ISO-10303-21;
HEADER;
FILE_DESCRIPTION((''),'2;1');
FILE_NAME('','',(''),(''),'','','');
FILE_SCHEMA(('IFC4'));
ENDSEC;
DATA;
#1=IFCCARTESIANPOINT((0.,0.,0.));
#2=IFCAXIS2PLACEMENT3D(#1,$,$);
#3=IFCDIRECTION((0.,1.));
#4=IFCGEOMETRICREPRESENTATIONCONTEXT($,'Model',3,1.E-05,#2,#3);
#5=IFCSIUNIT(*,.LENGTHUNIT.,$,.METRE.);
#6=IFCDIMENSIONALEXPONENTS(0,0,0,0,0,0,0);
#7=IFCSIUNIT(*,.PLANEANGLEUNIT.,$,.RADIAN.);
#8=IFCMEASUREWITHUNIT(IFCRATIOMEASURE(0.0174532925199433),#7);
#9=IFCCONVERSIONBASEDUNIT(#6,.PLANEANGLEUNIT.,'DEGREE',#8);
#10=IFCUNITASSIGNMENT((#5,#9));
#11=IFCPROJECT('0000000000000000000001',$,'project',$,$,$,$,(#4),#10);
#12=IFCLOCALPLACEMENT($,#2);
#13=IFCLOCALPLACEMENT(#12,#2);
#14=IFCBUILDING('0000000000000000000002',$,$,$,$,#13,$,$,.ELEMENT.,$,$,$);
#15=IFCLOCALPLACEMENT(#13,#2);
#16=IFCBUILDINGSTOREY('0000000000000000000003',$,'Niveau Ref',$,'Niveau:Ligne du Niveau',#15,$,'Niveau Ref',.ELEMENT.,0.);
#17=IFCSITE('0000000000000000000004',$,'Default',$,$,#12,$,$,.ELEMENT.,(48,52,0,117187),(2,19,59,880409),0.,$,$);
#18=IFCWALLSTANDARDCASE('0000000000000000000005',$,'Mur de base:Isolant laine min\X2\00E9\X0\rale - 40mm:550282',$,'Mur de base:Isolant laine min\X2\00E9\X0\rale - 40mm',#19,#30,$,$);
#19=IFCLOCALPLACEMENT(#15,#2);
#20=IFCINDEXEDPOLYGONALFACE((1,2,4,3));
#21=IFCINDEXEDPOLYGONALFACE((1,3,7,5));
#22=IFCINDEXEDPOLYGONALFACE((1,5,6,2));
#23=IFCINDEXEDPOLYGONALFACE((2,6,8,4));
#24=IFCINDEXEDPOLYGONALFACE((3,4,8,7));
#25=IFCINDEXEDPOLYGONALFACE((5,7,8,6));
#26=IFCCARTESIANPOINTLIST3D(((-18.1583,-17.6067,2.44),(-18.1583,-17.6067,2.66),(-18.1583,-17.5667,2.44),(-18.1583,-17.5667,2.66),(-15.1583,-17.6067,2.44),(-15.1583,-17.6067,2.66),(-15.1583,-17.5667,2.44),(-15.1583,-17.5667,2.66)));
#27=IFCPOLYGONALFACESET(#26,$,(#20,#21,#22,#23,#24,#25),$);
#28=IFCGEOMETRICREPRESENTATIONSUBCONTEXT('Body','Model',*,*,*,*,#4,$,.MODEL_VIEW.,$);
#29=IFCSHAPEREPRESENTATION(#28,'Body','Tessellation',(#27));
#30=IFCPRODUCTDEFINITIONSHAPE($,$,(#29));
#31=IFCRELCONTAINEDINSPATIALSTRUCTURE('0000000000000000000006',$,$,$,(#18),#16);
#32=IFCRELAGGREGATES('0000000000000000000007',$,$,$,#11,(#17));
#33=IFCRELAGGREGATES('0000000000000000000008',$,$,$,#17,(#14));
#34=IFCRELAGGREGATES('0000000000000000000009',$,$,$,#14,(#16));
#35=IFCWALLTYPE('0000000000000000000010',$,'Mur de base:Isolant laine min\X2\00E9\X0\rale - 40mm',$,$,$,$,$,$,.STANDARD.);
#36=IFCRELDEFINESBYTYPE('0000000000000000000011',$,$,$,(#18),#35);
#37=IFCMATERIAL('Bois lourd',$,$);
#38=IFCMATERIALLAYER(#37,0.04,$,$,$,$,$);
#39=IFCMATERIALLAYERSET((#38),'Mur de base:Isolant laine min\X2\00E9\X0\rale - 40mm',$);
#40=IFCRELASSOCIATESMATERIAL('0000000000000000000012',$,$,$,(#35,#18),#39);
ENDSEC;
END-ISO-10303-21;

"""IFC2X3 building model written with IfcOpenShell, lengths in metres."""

from ifc_helpers import new_model, entity, si_unit, converted_unit, direction, frame, frame_2d, origin, place, context, subcontext, project, spatial, rectangle, extrude, material, layer, layer_set, layer_usage, type_object, element, save


model = new_model("IFC2X3")

# Units and contexts
model_context = context("Model", 3, precision=1e-05, world=origin(), true_north=direction((0.0, 1.0)))
body_context = subcontext(model_context, "Body", "Model", "MODEL_VIEW")
ifc_project = project(units=[si_unit("LENGTHUNIT", "METRE"), converted_unit("PLANEANGLEUNIT", "DEGREE", entity("IfcRatioMeasure", 0.0174532925199433), si_unit("PLANEANGLEUNIT", "RADIAN"), dimensions=[0, 0, 0, 0, 0, 0, 0])], contexts=[model_context])

# Site, building, storey
site_placement = place(None, origin())
site = spatial("IfcSite", under=ifc_project, at=site_placement, Name="Default", CompositionType="ELEMENT", RefLatitude=(48, 52, 0, 117187), RefLongitude=(2, 19, 59, 880409), RefElevation=0.0)
building_placement = place(site_placement, origin())
building = spatial("IfcBuilding", under=site, at=building_placement, CompositionType="ELEMENT")
storey_placement = place(building_placement, origin())
storey = spatial("IfcBuildingStorey", under=building, at=storey_placement, Name="Niveau Ref", ObjectType="Niveau:Ligne du Niveau", LongName="Niveau Ref", CompositionType="ELEMENT", Elevation=0.0)

# Wall
ifc_material_1 = material(Name="Bois lourd")
ifc_layer = layer(ifc_material_1, 0.04)
ifc_layer_set = layer_set([ifc_layer], Name="Mur de base:Isolant laine minérale - 40mm")
wall_type = type_object("IfcWallType", Name="Mur de base:Isolant laine minérale - 40mm", PredefinedType="STANDARD", material=ifc_layer_set)
ifc_layer_usage_1 = layer_usage(ifc_layer_set, "AXIS2", "NEGATIVE", 0.02)
wall_1_placement = place(storey_placement, frame((-18.1583, -17.5867, 2.44)))
element("IfcWallStandardCase", 1, at=wall_1_placement, inside=storey, type_object=wall_type, material=ifc_layer_usage_1, Name="Mur de base:Isolant laine minérale - 40mm:550282", ObjectType="Mur de base:Isolant laine minérale - 40mm", context=body_context, shape_type="SweptSolid", body=[
    extrude(rectangle(XDim=3.0, YDim=0.04, at=frame_2d((1.5, 0.0), x_axis=(-1.0, 0.0))), origin(), (0.0, 0.0, 1.0), 0.22),
])

save(model, "model.ifc")
